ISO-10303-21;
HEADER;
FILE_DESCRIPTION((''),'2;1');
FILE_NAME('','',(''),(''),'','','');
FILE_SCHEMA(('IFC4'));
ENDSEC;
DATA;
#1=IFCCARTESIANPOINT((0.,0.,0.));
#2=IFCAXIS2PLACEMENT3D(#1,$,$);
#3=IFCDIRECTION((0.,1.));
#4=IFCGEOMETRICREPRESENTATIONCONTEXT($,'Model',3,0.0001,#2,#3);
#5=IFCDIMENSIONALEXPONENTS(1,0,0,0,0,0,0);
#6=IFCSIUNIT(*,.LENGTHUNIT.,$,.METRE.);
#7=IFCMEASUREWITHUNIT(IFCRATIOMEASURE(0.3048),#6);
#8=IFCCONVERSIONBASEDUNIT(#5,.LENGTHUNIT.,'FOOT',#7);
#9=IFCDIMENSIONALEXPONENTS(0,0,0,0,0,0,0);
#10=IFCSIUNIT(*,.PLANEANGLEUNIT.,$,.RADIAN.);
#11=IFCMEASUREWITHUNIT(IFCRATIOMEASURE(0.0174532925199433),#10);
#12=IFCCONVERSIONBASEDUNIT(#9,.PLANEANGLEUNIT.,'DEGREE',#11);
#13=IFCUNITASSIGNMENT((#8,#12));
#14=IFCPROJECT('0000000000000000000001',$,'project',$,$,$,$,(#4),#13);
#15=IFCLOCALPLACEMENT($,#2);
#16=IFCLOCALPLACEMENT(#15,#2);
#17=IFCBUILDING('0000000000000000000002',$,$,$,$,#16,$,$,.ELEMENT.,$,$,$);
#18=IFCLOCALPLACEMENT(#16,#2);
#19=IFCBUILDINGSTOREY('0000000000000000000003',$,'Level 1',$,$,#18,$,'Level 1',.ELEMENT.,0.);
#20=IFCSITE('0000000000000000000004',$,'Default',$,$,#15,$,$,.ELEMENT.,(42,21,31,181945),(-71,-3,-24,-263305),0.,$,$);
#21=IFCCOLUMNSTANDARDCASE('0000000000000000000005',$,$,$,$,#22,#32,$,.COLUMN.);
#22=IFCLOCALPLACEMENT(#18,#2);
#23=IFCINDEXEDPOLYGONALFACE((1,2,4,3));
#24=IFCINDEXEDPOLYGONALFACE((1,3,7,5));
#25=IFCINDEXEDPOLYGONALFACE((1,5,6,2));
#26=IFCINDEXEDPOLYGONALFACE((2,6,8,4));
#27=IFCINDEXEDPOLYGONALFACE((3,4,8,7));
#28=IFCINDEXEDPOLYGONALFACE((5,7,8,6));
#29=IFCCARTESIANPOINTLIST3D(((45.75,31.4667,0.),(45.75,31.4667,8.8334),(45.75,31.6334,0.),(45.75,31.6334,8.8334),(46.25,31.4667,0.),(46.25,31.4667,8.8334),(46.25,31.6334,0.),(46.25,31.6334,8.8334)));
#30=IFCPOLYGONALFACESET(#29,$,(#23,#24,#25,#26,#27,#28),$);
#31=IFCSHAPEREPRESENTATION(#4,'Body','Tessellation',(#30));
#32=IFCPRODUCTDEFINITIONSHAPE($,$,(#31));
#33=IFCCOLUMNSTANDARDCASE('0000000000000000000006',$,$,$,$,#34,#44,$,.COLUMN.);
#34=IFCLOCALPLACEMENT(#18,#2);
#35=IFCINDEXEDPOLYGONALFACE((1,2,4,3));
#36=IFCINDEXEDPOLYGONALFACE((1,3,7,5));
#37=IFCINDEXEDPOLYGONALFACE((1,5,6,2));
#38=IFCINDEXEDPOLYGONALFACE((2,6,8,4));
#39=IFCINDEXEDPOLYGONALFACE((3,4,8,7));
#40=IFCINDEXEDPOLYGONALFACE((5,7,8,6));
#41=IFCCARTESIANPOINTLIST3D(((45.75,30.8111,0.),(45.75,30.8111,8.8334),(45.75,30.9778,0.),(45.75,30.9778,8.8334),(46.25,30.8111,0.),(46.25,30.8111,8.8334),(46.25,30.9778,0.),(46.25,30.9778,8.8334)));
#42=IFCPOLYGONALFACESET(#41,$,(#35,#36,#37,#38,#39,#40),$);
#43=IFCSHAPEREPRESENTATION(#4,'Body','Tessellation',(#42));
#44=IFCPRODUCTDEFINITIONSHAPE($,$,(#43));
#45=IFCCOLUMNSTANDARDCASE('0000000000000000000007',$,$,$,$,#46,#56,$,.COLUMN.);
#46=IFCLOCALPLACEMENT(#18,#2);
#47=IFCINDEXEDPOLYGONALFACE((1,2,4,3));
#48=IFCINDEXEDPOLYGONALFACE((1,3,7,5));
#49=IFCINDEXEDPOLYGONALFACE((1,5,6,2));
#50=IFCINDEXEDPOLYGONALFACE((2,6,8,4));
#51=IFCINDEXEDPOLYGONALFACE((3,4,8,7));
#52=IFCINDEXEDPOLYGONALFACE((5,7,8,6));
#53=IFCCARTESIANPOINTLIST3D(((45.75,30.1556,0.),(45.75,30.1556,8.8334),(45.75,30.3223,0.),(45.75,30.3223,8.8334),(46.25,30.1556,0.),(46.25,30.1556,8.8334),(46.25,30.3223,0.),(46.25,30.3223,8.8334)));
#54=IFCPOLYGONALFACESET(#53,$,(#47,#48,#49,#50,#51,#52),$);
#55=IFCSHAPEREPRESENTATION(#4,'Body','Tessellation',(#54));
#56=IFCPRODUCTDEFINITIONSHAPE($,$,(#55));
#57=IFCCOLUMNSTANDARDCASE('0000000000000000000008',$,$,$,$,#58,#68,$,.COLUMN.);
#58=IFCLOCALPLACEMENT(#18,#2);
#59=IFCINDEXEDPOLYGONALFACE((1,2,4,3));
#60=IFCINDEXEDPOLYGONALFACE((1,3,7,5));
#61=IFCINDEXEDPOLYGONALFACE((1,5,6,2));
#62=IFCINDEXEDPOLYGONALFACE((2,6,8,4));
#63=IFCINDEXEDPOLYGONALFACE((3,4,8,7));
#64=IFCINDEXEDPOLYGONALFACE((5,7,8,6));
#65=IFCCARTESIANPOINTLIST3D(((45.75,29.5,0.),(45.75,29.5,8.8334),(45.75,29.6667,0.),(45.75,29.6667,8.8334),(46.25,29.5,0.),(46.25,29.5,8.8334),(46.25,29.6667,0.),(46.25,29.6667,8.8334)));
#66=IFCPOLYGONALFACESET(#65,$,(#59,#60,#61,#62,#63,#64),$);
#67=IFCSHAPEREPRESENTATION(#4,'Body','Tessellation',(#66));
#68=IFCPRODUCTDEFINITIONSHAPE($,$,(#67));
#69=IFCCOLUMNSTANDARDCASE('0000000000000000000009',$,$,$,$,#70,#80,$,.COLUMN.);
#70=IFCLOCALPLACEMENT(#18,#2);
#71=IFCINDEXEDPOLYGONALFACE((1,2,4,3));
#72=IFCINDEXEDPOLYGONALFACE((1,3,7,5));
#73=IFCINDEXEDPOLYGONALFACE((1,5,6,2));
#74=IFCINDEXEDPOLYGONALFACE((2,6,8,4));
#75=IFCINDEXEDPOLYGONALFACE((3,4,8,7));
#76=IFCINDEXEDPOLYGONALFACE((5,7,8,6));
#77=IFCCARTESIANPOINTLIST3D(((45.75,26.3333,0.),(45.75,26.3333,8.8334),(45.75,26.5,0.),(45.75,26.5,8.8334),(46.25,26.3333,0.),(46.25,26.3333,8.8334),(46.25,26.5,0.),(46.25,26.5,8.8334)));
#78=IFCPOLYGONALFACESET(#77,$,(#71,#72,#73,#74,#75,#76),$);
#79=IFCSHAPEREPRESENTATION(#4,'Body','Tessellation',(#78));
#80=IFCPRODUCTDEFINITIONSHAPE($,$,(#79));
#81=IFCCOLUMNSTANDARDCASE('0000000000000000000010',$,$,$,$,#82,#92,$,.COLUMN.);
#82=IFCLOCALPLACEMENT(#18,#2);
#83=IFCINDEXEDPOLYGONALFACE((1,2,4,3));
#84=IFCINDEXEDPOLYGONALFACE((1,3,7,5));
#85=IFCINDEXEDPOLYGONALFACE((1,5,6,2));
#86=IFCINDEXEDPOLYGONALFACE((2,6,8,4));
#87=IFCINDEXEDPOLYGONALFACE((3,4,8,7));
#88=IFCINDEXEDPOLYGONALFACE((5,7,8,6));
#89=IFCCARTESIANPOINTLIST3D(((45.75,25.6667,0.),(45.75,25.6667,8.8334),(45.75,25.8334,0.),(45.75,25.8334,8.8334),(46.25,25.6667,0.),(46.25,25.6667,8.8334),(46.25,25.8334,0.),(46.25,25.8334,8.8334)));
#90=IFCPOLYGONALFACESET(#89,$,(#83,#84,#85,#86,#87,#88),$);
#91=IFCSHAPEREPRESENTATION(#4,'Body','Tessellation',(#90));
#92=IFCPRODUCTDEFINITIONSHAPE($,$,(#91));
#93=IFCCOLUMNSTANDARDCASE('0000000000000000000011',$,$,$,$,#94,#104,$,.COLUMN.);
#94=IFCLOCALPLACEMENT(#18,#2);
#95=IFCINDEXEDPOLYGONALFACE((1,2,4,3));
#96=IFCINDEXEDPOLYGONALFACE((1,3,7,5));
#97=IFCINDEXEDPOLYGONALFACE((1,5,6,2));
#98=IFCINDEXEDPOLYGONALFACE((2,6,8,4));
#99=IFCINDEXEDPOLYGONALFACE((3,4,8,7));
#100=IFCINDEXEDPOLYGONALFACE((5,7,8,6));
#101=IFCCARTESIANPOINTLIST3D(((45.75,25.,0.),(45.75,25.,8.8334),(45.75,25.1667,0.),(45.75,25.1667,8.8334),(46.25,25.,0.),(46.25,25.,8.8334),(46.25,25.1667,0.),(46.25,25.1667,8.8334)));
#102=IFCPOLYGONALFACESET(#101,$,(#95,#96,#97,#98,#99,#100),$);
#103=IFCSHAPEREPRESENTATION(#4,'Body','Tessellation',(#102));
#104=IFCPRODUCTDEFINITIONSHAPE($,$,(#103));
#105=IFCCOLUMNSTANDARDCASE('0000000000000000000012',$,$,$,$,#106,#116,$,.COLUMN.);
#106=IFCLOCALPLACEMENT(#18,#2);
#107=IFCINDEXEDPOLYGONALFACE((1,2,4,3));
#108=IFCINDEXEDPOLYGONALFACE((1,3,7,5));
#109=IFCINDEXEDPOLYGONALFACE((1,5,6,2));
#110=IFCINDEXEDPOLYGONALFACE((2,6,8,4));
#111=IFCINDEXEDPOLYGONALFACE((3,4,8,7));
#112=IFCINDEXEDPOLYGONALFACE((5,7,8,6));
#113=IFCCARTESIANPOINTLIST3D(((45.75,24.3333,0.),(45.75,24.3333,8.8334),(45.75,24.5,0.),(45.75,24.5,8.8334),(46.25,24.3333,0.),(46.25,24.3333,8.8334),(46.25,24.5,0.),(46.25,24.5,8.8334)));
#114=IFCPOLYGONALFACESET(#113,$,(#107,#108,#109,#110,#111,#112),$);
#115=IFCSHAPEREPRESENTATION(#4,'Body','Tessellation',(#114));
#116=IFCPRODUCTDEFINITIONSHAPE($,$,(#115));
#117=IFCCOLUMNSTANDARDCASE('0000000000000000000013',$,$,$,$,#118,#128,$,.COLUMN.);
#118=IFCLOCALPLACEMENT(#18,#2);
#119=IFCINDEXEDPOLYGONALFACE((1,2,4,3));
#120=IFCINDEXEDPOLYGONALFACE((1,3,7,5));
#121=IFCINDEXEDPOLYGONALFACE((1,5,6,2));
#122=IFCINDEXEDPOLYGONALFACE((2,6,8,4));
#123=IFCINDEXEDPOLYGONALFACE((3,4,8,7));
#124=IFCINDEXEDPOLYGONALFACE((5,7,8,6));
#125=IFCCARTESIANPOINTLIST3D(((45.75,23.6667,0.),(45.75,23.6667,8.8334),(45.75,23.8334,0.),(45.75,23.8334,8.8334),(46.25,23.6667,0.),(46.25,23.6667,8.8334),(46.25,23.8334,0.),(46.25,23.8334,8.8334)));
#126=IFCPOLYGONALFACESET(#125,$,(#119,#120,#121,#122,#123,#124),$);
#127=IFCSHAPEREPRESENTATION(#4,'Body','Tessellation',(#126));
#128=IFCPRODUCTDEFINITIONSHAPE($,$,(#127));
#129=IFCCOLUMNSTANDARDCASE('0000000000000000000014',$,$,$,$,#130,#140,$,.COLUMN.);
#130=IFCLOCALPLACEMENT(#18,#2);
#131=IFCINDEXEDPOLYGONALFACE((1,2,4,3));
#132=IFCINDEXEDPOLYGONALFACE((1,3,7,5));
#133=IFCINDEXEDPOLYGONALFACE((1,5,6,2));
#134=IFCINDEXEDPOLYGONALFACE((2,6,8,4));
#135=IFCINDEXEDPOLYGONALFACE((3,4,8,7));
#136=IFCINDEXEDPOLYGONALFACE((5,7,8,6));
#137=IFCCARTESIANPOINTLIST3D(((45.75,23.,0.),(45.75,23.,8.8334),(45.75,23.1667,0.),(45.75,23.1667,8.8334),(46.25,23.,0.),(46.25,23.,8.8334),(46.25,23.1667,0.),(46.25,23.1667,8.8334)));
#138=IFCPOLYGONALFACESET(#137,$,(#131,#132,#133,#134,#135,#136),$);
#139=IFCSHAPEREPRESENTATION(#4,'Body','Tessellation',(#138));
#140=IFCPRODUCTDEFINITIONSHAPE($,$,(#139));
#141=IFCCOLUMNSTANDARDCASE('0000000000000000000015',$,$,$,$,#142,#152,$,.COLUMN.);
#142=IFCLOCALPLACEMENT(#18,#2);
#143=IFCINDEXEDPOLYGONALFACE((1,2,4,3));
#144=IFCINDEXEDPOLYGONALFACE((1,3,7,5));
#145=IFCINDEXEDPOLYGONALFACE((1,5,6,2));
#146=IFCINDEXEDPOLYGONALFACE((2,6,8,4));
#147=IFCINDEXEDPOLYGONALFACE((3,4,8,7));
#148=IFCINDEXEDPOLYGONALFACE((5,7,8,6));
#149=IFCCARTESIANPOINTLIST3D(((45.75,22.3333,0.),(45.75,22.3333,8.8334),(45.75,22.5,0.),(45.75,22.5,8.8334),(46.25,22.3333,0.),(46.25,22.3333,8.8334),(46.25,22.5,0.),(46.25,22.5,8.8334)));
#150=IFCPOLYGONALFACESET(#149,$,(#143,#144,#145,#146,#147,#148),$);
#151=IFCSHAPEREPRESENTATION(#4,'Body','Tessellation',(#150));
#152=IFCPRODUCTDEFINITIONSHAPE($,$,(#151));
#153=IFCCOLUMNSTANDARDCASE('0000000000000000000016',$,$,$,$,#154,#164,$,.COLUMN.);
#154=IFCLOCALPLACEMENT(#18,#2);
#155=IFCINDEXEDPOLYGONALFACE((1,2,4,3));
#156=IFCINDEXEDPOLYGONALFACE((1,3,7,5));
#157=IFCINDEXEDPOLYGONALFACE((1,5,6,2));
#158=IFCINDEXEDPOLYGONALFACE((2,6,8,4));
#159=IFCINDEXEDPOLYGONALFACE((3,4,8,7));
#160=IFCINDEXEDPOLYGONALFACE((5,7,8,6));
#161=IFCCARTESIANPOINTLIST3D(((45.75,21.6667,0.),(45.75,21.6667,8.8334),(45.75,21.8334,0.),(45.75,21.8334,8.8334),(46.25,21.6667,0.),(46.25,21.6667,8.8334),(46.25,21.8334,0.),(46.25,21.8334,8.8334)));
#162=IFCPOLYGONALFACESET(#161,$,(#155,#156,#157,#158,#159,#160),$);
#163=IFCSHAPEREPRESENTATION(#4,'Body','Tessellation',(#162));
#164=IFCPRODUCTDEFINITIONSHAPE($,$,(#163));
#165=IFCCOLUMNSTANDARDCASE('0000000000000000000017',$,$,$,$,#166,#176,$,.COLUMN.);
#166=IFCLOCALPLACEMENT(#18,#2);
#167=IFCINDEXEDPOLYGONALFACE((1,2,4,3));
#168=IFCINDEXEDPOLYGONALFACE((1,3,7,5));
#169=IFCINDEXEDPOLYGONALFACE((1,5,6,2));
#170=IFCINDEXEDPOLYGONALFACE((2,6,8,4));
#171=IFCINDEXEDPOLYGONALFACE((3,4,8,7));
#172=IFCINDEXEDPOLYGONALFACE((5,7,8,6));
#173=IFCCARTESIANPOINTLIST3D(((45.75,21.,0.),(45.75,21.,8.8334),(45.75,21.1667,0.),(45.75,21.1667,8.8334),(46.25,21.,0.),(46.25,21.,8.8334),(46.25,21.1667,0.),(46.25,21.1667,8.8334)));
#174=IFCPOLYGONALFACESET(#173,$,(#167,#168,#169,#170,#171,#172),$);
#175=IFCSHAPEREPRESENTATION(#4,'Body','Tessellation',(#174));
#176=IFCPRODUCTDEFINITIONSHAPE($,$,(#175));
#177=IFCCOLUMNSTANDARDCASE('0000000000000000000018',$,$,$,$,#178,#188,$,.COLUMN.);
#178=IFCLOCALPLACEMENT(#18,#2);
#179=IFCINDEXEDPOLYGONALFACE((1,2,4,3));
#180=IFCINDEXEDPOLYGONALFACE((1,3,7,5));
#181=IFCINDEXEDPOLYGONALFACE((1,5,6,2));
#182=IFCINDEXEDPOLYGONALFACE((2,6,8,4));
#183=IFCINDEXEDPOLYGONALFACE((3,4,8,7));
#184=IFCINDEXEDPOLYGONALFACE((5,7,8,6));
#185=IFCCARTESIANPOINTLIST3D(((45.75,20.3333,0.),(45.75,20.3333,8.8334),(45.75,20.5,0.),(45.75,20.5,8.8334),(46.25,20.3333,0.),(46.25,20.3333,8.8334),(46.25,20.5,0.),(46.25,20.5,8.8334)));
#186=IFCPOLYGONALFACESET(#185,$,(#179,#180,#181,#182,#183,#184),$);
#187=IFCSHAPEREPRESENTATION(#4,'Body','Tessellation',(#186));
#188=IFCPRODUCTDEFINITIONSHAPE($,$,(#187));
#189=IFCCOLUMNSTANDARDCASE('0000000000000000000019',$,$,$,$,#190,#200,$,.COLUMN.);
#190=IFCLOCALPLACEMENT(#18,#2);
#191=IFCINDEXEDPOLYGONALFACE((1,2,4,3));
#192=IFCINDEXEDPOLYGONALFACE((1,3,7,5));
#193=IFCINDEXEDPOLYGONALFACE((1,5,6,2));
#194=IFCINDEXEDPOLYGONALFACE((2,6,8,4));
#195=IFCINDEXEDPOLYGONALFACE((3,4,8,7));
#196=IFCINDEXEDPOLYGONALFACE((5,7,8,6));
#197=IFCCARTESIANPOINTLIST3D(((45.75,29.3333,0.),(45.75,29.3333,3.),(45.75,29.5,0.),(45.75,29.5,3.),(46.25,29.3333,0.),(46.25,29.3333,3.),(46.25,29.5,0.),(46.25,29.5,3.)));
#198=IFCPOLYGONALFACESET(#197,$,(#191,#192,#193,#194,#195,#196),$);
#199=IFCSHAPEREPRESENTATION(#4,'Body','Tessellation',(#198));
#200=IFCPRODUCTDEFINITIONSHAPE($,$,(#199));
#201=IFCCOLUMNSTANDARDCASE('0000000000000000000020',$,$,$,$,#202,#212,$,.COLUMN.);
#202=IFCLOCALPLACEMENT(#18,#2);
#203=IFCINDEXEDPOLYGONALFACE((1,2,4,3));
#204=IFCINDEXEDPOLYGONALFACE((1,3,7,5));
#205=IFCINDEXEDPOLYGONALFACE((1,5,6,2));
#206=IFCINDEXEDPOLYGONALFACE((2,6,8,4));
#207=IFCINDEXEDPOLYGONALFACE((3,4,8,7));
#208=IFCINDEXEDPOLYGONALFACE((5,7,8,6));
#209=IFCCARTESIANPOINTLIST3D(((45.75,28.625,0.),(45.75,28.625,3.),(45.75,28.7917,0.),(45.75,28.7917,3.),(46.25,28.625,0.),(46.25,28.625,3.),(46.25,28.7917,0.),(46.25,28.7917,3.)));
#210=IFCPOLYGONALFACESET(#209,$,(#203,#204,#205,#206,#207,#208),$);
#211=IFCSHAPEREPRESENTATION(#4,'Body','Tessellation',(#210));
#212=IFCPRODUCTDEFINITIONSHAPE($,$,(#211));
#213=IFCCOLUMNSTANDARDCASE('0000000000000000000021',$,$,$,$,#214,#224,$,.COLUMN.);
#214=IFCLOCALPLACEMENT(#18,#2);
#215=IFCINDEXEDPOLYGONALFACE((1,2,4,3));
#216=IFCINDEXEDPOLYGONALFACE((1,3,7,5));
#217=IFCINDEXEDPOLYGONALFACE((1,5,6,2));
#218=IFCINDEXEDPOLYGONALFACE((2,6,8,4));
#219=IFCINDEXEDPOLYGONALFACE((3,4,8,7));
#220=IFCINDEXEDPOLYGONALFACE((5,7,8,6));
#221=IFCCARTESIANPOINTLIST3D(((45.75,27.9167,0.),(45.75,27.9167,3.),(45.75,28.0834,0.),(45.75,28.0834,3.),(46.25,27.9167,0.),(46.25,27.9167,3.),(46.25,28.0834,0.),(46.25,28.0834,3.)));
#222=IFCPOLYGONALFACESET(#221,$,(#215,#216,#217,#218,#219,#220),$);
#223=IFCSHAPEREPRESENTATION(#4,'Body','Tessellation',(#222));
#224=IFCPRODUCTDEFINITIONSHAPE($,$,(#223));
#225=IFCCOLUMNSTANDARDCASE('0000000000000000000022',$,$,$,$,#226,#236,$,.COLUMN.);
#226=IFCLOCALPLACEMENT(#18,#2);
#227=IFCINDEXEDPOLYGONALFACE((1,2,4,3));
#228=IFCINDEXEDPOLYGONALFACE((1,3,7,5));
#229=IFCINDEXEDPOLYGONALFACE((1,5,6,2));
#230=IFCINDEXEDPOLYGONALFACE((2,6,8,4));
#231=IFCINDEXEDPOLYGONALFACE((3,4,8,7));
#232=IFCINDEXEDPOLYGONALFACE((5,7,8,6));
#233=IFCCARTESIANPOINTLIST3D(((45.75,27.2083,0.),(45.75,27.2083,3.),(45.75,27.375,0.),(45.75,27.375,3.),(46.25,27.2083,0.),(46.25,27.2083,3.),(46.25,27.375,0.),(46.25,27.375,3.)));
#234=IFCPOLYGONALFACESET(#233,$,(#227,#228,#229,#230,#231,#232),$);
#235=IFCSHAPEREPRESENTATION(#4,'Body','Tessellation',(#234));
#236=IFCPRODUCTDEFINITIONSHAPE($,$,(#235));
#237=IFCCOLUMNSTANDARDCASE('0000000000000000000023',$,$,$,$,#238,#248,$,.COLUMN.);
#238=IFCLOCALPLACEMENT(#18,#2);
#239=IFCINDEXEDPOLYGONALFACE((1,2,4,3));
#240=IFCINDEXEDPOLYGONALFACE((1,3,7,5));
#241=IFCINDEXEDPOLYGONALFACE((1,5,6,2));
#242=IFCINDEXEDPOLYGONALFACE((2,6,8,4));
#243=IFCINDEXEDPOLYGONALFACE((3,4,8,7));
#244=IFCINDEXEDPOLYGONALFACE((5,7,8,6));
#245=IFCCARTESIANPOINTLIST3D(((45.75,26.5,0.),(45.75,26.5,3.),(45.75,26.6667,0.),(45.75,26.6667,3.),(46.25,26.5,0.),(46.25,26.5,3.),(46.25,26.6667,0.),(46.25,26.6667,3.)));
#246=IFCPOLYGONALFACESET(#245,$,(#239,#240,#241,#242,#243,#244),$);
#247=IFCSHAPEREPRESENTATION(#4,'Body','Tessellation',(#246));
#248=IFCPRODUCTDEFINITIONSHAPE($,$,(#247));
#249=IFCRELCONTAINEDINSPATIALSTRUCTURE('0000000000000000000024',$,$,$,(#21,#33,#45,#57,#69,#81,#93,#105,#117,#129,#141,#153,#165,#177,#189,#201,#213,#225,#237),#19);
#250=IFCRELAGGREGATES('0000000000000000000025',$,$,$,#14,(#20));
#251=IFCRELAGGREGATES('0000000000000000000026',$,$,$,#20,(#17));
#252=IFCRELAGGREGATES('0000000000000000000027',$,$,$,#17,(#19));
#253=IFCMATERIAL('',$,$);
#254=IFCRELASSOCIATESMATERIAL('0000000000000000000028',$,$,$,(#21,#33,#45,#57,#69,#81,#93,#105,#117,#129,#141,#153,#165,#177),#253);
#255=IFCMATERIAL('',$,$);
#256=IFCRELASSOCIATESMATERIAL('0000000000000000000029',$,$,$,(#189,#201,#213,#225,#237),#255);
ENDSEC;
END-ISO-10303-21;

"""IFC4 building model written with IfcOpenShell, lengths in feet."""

from ifc_helpers import new_model, entity, si_unit, converted_unit, direction, frame, origin, place, context, project, spatial, rectangle, extrude, material, element, save


model = new_model("IFC4")

# Units and contexts
model_context = context("Model", 3, precision=0.0001, world=origin(), true_north=direction((0.0, 1.0)))
ifc_project = project(units=[converted_unit("LENGTHUNIT", "FOOT", entity("IfcRatioMeasure", 0.3048), si_unit("LENGTHUNIT", "METRE"), dimensions=[1, 0, 0, 0, 0, 0, 0]), converted_unit("PLANEANGLEUNIT", "DEGREE", entity("IfcRatioMeasure", 0.0174532925199433), si_unit("PLANEANGLEUNIT", "RADIAN"), dimensions=[0, 0, 0, 0, 0, 0, 0])], contexts=[model_context])

# Site, building, storey
site_placement = place(None, origin())
site = spatial("IfcSite", under=ifc_project, at=site_placement, Name="Default", CompositionType="ELEMENT", RefLatitude=(42, 21, 31, 181945), RefLongitude=(-71, -3, -24, -263305), RefElevation=0.0)
building_placement = place(site_placement, origin())
building = spatial("IfcBuilding", under=site, at=building_placement, CompositionType="ELEMENT")
storey_placement = place(building_placement, origin())
storey = spatial("IfcBuildingStorey", under=building, at=storey_placement, Name="Level 1", LongName="Level 1", CompositionType="ELEMENT", Elevation=0.0)

# Columns
ifc_material_1 = material(Name="")
placement_1 = place(storey_placement, frame((46.0, 46.25, 0.0), z_axis=(0.0, 0.0, 1.0), x_axis=(0.0, -1.0, 0.0)))
for number, where, z_axis, x_axis in (
    (1, (14.7, 0.0, 0.0), (0.0, 0.0, 1.0), (1.0, 0.0, 0.0)),
    (2, (15.3556, 0.0, 0.0), (0.0, 0.0, 1.0), (1.0, 0.0, 0.0)),
    (3, (16.0111, 0.0, 0.0), (0.0, 0.0, 1.0), (1.0, 0.0, 0.0)),
    (4, (16.6667, 0.0, 0.0), (0.0, 0.0, 1.0), (1.0, 0.0, 0.0)),
    (5, (19.8334, 0.0, 0.0), (0.0, 0.0, 1.0), (1.0, 0.0, 0.0)),
    (6, (20.5, 0.0, 0.0), (0.0, 0.0, 1.0), (1.0, 0.0, 0.0)),
    (7, (21.1667, 0.0, 0.0), (0.0, 0.0, 1.0), (1.0, 0.0, 0.0)),
    (8, (21.8334, 0.0, 0.0), (0.0, 0.0, 1.0), (1.0, 0.0, 0.0)),
    (9, (22.5, 0.0, 0.0), (0.0, 0.0, 1.0), (1.0, 0.0, 0.0)),
    (10, (23.1667, 0.0, 0.0), (0.0, 0.0, 1.0), (1.0, 0.0, 0.0)),
    (11, (23.8334, 0.0, 0.0), (0.0, 0.0, 1.0), (1.0, 0.0, 0.0)),
    (12, (24.5, 0.0, 0.0), (0.0, 0.0, 1.0), (1.0, 0.0, 0.0)),
    (13, (25.1667, 0.0, 0.0), (0.0, 0.0, 1.0), (1.0, 0.0, 0.0)),
    (14, (25.8334, 0.0, 0.0), (0.0, 0.0, 1.0), (1.0, 0.0, 0.0)),
):
    element("IfcColumnStandardCase", number, at=place(placement_1, frame(where, z_axis=z_axis, x_axis=x_axis)), inside=storey, material=ifc_material_1, PredefinedType="COLUMN", context=model_context, shape_type="SweptSolid", body=[
        extrude(rectangle(XDim=0.1667, YDim=0.5), origin(), (0.0, 0.0, 1.0), 8.8334),
    ])
ifc_material_2 = material(Name="")
for number, where, z_axis, x_axis in (
    (15, (16.8334, 0.0, 0.0), (0.0, 0.0, 1.0), (1.0, 0.0, 0.0)),
    (16, (17.5417, 0.0, 0.0), (0.0, 0.0, 1.0), (1.0, 0.0, 0.0)),
    (17, (18.25, 0.0, 0.0), (0.0, 0.0, 1.0), (1.0, 0.0, 0.0)),
    (18, (18.9584, 0.0, 0.0), (0.0, 0.0, 1.0), (1.0, 0.0, 0.0)),
    (19, (19.6667, 0.0, 0.0), (0.0, 0.0, 1.0), (1.0, 0.0, 0.0)),
):
    element("IfcColumnStandardCase", number, at=place(placement_1, frame(where, z_axis=z_axis, x_axis=x_axis)), inside=storey, material=ifc_material_2, PredefinedType="COLUMN", context=model_context, shape_type="SweptSolid", body=[
        extrude(rectangle(XDim=0.1667, YDim=0.5), origin(), (0.0, 0.0, 1.0), 3.0),
    ])

save(model, "model.ifc")
